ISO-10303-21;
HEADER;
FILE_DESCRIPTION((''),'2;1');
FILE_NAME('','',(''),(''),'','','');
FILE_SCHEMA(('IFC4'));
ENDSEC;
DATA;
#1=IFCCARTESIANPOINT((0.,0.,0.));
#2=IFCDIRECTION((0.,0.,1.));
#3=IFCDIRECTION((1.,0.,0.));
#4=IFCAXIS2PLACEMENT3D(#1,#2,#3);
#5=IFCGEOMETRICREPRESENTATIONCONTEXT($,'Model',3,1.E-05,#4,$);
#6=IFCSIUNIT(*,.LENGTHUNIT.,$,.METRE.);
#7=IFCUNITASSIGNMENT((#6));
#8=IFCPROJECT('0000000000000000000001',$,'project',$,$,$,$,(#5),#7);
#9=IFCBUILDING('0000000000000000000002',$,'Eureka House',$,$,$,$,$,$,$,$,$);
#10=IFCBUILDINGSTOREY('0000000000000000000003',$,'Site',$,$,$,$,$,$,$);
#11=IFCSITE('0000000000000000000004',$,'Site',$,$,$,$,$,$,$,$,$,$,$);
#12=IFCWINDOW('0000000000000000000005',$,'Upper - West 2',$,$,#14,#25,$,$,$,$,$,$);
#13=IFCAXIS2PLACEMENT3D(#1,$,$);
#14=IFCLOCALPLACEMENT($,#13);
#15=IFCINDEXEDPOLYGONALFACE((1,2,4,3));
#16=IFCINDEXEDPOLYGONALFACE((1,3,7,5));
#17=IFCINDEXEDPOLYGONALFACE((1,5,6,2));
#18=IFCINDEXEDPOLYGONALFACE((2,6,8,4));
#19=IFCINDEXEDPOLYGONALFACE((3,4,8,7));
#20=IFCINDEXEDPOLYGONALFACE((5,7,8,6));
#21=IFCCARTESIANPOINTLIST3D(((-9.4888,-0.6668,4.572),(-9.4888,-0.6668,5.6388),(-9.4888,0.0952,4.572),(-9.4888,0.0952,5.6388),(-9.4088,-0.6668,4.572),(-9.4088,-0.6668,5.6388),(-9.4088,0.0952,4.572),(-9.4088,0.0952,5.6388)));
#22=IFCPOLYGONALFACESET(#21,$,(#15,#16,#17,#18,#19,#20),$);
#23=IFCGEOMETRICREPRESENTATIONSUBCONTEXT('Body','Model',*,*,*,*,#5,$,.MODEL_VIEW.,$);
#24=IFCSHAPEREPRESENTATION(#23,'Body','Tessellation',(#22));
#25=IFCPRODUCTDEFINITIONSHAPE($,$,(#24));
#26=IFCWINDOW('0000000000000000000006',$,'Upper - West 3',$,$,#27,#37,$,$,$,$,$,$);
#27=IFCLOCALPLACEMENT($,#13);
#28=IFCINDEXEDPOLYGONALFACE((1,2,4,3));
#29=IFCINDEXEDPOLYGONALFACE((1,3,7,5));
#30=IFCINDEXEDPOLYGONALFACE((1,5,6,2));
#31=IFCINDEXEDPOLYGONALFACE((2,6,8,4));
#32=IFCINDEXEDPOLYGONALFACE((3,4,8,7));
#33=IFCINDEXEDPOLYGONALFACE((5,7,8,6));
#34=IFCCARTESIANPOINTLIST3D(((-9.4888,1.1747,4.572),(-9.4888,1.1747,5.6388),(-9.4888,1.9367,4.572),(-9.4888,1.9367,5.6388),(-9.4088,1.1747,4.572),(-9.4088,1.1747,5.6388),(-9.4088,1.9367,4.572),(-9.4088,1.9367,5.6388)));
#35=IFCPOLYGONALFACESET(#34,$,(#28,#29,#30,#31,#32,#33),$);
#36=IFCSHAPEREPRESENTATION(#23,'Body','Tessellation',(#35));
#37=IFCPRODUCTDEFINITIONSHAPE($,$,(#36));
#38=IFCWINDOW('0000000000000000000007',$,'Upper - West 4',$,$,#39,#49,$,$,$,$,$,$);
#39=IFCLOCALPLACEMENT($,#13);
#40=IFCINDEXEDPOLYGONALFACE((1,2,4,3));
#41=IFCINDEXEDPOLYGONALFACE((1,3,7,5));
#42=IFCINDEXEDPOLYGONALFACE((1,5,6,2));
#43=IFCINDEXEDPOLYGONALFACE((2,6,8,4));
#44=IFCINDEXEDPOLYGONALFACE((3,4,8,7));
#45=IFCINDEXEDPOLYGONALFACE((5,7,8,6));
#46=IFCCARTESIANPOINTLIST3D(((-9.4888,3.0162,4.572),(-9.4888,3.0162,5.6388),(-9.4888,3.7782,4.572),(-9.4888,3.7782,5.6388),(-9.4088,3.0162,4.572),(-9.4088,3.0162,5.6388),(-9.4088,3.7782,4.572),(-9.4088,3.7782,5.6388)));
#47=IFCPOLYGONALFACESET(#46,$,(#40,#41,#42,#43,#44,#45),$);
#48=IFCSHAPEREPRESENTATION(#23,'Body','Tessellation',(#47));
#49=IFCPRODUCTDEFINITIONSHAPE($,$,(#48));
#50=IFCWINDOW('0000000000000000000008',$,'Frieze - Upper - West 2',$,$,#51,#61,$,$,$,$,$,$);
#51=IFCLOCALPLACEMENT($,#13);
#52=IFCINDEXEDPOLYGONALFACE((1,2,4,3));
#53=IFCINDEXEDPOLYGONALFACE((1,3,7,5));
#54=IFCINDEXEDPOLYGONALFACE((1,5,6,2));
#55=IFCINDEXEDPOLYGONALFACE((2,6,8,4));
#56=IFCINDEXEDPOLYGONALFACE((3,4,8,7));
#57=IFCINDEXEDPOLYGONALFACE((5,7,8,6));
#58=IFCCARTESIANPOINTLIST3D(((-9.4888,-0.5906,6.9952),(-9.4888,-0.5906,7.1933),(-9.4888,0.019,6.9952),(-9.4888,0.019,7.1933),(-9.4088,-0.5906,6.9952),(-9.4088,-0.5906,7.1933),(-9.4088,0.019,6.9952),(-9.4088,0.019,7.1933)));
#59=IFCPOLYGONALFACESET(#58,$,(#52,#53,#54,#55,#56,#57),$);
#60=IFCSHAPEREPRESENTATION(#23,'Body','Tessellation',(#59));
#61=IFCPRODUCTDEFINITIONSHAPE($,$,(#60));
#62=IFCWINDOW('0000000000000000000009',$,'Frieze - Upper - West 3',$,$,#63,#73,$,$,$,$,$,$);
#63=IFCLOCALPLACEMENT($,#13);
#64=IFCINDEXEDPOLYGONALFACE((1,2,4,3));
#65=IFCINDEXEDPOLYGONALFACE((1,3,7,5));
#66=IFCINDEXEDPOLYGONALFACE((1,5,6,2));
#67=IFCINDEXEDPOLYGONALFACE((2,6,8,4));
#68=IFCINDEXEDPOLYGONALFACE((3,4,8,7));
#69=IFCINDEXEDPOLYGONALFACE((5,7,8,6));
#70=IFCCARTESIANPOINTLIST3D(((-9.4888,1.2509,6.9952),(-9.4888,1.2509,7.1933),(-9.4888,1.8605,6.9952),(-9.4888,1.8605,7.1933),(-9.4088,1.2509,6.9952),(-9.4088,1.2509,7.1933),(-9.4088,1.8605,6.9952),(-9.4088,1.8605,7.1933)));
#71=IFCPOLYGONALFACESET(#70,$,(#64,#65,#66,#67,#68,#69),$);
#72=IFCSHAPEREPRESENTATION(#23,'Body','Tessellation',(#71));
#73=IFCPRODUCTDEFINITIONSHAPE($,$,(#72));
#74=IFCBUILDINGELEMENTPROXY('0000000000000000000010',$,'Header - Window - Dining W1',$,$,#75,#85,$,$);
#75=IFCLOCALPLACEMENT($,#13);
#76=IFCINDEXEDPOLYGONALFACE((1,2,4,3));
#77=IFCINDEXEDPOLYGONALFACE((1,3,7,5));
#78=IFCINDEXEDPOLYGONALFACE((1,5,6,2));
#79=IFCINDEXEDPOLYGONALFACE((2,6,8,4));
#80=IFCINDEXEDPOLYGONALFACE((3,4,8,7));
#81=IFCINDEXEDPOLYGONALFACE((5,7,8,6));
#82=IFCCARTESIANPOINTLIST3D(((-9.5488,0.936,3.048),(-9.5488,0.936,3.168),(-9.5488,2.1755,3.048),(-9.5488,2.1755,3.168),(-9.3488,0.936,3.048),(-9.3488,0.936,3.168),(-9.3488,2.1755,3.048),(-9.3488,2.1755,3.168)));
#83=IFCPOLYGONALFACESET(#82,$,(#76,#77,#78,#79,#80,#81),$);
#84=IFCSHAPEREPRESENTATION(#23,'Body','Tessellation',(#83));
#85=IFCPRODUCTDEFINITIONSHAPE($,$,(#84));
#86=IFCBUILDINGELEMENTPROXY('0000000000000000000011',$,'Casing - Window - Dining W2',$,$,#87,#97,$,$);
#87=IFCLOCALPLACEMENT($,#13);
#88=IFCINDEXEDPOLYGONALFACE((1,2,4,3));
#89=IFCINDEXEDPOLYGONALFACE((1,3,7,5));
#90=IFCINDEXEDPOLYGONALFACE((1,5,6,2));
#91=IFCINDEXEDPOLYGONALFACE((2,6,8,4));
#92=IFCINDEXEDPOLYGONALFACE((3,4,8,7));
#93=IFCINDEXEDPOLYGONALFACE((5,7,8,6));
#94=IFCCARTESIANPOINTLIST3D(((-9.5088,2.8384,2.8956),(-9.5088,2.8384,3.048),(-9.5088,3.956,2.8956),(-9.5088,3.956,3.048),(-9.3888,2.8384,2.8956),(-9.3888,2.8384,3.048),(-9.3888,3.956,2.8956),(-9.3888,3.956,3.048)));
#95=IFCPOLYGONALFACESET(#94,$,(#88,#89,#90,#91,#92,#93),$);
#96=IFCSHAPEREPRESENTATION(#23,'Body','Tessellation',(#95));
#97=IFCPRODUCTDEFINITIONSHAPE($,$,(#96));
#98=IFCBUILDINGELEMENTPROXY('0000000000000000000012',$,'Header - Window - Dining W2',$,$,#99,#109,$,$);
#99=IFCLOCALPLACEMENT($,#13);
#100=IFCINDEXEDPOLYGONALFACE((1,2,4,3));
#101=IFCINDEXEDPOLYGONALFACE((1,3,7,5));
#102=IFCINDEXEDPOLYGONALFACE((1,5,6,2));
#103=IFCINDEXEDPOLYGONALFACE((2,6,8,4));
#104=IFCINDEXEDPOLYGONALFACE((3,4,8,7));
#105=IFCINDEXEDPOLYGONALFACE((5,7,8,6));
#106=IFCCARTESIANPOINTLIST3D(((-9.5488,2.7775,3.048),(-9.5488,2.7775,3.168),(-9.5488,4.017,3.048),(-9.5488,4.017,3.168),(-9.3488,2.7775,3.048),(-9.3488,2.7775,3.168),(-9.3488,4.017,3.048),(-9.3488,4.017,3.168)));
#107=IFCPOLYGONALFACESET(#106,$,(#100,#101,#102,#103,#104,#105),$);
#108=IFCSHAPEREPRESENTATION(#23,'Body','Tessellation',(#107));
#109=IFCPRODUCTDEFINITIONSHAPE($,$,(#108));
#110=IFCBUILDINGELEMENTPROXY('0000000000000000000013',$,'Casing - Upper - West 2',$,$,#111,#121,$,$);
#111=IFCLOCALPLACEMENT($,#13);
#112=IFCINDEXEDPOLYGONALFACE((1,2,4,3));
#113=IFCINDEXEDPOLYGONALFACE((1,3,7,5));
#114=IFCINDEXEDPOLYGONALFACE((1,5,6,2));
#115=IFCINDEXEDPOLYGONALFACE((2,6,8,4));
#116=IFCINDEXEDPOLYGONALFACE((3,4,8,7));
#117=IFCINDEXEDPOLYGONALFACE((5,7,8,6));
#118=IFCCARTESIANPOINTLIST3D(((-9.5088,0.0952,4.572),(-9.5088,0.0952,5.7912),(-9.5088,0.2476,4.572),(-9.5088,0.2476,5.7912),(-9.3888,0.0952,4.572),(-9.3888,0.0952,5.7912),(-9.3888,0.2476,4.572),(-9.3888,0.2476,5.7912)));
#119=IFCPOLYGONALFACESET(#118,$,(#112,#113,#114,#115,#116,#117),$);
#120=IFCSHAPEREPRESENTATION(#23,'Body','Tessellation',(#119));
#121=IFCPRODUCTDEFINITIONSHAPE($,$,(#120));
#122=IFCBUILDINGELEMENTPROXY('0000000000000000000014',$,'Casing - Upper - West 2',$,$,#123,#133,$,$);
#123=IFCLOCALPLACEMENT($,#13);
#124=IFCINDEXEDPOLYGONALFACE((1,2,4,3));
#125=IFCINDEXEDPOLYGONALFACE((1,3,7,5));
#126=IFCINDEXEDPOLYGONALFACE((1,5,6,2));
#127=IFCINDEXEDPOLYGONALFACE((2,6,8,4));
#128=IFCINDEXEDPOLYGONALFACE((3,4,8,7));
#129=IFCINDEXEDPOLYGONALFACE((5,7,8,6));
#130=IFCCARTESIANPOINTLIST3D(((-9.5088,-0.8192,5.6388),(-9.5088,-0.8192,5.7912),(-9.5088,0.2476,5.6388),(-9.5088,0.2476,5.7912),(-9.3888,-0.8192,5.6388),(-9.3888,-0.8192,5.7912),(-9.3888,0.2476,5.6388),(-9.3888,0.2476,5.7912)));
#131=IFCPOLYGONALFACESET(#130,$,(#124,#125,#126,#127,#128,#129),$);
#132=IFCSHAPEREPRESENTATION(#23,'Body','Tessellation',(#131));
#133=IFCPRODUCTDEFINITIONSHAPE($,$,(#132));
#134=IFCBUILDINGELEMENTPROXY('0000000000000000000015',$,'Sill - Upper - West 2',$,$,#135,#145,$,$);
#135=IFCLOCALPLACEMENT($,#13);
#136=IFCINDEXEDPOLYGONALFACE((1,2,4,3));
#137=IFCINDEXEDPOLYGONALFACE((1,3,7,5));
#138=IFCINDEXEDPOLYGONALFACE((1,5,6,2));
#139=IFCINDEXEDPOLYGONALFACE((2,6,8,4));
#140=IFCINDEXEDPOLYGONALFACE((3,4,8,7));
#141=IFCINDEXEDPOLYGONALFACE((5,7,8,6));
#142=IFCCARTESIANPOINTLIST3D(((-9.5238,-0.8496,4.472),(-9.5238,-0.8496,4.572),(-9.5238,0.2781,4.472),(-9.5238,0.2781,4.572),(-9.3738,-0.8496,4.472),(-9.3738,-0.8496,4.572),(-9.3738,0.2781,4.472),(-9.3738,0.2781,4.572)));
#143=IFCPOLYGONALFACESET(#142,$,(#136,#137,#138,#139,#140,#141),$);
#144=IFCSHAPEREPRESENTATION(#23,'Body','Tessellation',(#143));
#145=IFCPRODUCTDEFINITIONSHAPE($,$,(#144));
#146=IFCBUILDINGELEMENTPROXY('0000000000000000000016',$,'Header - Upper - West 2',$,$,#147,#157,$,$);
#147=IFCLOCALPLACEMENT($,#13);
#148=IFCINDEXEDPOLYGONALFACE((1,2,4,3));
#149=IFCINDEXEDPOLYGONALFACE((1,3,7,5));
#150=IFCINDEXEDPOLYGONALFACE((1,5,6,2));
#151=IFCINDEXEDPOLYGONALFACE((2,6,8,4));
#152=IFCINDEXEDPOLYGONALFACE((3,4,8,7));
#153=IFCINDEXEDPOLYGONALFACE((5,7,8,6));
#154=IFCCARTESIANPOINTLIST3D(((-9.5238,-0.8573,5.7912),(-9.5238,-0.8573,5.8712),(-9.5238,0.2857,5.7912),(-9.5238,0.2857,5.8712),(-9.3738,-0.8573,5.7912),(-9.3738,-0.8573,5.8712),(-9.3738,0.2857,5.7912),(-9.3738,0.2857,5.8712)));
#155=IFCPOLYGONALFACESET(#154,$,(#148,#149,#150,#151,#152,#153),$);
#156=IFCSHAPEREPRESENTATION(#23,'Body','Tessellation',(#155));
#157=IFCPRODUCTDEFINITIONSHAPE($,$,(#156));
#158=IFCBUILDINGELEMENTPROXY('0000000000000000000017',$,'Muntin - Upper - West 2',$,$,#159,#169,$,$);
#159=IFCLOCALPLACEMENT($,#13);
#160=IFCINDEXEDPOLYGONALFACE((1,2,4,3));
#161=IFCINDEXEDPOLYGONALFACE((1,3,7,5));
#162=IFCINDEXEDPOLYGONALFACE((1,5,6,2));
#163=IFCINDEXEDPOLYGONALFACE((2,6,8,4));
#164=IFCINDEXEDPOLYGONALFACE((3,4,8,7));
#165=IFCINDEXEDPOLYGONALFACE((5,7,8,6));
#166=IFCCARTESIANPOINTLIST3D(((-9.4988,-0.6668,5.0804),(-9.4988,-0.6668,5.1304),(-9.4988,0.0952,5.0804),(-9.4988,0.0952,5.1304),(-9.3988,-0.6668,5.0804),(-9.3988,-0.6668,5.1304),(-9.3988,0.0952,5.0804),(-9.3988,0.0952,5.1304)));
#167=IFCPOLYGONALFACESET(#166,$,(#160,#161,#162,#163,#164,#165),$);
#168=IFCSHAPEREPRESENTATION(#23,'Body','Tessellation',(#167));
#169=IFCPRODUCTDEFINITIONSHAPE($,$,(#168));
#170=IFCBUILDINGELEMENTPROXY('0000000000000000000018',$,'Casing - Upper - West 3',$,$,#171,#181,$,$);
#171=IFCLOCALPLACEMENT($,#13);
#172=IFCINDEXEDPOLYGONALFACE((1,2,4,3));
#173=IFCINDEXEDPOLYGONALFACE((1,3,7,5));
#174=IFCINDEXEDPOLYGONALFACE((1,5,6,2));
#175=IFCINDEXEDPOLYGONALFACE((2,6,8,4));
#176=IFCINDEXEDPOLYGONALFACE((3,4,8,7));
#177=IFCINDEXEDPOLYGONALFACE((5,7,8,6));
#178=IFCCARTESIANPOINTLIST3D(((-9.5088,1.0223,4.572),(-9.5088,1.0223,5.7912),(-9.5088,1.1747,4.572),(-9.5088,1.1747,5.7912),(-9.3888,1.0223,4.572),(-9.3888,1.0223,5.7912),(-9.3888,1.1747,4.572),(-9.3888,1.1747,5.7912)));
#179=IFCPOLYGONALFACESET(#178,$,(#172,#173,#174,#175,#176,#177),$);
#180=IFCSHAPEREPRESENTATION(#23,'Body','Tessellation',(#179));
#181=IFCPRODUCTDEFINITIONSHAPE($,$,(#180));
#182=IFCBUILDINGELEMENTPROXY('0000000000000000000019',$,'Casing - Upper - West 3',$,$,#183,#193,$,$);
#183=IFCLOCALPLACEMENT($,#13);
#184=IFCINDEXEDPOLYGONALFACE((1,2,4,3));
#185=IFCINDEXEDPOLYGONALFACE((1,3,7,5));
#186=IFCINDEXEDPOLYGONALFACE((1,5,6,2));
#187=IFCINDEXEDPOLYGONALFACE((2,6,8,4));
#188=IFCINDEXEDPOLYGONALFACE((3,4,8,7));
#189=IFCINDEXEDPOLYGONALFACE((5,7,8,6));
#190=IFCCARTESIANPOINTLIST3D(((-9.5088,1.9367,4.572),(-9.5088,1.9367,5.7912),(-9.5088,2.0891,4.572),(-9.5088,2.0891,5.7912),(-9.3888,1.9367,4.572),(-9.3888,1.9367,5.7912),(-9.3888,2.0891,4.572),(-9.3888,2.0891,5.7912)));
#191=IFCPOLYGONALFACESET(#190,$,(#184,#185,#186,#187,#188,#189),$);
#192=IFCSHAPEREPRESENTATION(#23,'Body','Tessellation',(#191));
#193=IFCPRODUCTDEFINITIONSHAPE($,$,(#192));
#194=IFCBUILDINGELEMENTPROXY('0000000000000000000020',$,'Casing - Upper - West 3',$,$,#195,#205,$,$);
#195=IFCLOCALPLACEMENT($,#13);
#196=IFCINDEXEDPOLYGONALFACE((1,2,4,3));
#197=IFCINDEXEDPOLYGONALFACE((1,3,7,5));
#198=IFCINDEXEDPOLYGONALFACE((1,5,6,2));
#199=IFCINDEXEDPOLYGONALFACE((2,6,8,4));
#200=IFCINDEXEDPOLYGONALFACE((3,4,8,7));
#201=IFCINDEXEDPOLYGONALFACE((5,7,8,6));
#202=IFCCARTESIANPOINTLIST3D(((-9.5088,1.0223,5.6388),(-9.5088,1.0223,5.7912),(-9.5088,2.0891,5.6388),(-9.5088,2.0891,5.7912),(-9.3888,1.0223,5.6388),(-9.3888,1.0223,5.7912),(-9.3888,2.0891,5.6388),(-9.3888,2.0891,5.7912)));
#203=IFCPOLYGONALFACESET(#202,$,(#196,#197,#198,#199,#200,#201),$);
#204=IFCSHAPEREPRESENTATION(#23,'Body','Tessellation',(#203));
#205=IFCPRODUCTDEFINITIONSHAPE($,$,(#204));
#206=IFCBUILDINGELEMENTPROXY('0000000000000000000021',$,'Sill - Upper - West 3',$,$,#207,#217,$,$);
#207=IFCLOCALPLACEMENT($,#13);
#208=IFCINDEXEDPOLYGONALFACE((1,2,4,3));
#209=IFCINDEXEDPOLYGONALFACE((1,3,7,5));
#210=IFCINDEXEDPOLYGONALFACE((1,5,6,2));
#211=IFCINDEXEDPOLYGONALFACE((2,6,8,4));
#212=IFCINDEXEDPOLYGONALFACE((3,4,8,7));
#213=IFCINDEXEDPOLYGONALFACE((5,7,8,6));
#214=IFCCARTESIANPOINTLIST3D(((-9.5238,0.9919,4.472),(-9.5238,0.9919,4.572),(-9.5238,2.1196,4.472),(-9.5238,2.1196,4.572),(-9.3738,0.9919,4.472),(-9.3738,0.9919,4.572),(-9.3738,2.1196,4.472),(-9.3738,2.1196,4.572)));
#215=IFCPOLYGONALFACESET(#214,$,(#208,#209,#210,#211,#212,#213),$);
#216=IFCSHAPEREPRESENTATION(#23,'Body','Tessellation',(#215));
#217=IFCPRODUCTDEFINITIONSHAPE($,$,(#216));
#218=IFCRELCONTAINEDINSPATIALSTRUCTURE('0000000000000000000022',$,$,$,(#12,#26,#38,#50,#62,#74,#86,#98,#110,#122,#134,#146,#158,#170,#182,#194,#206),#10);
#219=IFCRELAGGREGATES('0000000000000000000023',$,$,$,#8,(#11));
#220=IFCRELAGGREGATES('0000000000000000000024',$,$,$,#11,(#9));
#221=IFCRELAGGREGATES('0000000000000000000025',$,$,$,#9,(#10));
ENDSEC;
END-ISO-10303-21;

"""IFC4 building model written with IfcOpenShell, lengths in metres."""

from ifc_helpers import new_model, si_unit, frame, origin, origin_with_axes, origin_2d, place, context, subcontext, project, spatial, rectangle, extrude, element, save


model = new_model("IFC4")

# Units and contexts
model_context = context("Model", 3, precision=1e-05, world=origin_with_axes())
body_context = subcontext(model_context, "Body", "Model", "MODEL_VIEW")
ifc_project = project(units=[si_unit("LENGTHUNIT", "METRE")], contexts=[model_context])

# Site, building, storey
site = spatial("IfcSite", under=ifc_project, Name="Site")
building = spatial("IfcBuilding", under=site, Name="Eureka House")
storey = spatial("IfcBuildingStorey", under=building, Name="Site")

# Windows
for number, where, z_axis, x_axis, name in (
    (1, (-9.4488, -0.2858, 4.572), (0.0, 0.0, 1.0), (1.0, 0.0, 0.0), "Upper - West 2"),
    (2, (-9.4488, 1.5557, 4.572), (0.0, 0.0, 1.0), (1.0, 0.0, 0.0), "Upper - West 3"),
    (3, (-9.4488, 3.3972, 4.572), (0.0, 0.0, 1.0), (1.0, 0.0, 0.0), "Upper - West 4"),
):
    element("IfcWindow", number, at=place(None, frame(where, z_axis=z_axis, x_axis=x_axis)), inside=storey, Name=name, context=body_context, shape_type="SweptSolid", body=[
        extrude(rectangle(XDim=0.08, YDim=0.762, at=origin_2d()), origin(), (0.0, 0.0, 1.0), 1.0668),
    ])
for number, where, z_axis, x_axis, name in (
    (4, (-9.4488, -0.2858, 6.9952), (0.0, 0.0, 1.0), (1.0, 0.0, 0.0), "Frieze - Upper - West 2"),
    (5, (-9.4488, 1.5557, 6.9952), (0.0, 0.0, 1.0), (1.0, 0.0, 0.0), "Frieze - Upper - West 3"),
):
    element("IfcWindow", number, at=place(None, frame(where, z_axis=z_axis, x_axis=x_axis)), inside=storey, Name=name, context=body_context, shape_type="SweptSolid", body=[
        extrude(rectangle(XDim=0.08, YDim=0.6096, at=origin_2d()), origin(), (0.0, 0.0, 1.0), 0.1981),
    ])

# Building element proxies
proxy_1_placement = place(None, frame((-9.4488, 1.5557, 3.048), z_axis=(0.0, 0.0, 1.0), x_axis=(1.0, 0.0, 0.0)))
element("IfcBuildingElementProxy", 6, at=proxy_1_placement, inside=storey, Name="Header - Window - Dining W1", context=body_context, shape_type="SweptSolid", body=[
    extrude(rectangle(XDim=0.2, YDim=1.2395, at=origin_2d()), origin(), (0.0, 0.0, 1.0), 0.12),
])
proxy_2_placement = place(None, frame((-9.4488, 3.3972, 2.8956), z_axis=(0.0, 0.0, 1.0), x_axis=(1.0, 0.0, 0.0)))
element("IfcBuildingElementProxy", 7, at=proxy_2_placement, inside=storey, Name="Casing - Window - Dining W2", context=body_context, shape_type="SweptSolid", body=[
    extrude(rectangle(XDim=0.12, YDim=1.1176, at=origin_2d()), origin(), (0.0, 0.0, 1.0), 0.1524),
])
proxy_3_placement = place(None, frame((-9.4488, 3.3972, 3.048), z_axis=(0.0, 0.0, 1.0), x_axis=(1.0, 0.0, 0.0)))
element("IfcBuildingElementProxy", 8, at=proxy_3_placement, inside=storey, Name="Header - Window - Dining W2", context=body_context, shape_type="SweptSolid", body=[
    extrude(rectangle(XDim=0.2, YDim=1.2395, at=origin_2d()), origin(), (0.0, 0.0, 1.0), 0.12),
])
proxy_4_placement = place(None, frame((-9.4488, 0.1714, 4.572), z_axis=(0.0, 0.0, 1.0), x_axis=(1.0, 0.0, 0.0)))
element("IfcBuildingElementProxy", 9, at=proxy_4_placement, inside=storey, Name="Casing - Upper - West 2", context=body_context, shape_type="SweptSolid", body=[
    extrude(rectangle(XDim=0.12, YDim=0.1524, at=origin_2d()), origin(), (0.0, 0.0, 1.0), 1.2192),
])
proxy_5_placement = place(None, frame((-9.4488, -0.2858, 5.6388), z_axis=(0.0, 0.0, 1.0), x_axis=(1.0, 0.0, 0.0)))
element("IfcBuildingElementProxy", 10, at=proxy_5_placement, inside=storey, Name="Casing - Upper - West 2", context=body_context, shape_type="SweptSolid", body=[
    extrude(rectangle(XDim=0.12, YDim=1.0668, at=origin_2d()), origin(), (0.0, 0.0, 1.0), 0.1524),
])
proxy_6_placement = place(None, frame((-9.4488, -0.2858, 4.472), z_axis=(0.0, 0.0, 1.0), x_axis=(1.0, 0.0, 0.0)))
element("IfcBuildingElementProxy", 11, at=proxy_6_placement, inside=storey, Name="Sill - Upper - West 2", context=body_context, shape_type="SweptSolid", body=[
    extrude(rectangle(XDim=0.15, YDim=1.1278, at=origin_2d()), origin(), (0.0, 0.0, 1.0), 0.1),
])
proxy_7_placement = place(None, frame((-9.4488, -0.2858, 5.7912), z_axis=(0.0, 0.0, 1.0), x_axis=(1.0, 0.0, 0.0)))
element("IfcBuildingElementProxy", 12, at=proxy_7_placement, inside=storey, Name="Header - Upper - West 2", context=body_context, shape_type="SweptSolid", body=[
    extrude(rectangle(XDim=0.15, YDim=1.143, at=origin_2d()), origin(), (0.0, 0.0, 1.0), 0.08),
])
proxy_8_placement = place(None, frame((-9.4488, -0.2858, 5.0804), z_axis=(0.0, 0.0, 1.0), x_axis=(1.0, 0.0, 0.0)))
element("IfcBuildingElementProxy", 13, at=proxy_8_placement, inside=storey, Name="Muntin - Upper - West 2", context=body_context, shape_type="SweptSolid", body=[
    extrude(rectangle(XDim=0.1, YDim=0.762, at=origin_2d()), origin(), (0.0, 0.0, 1.0), 0.05),
])
for number, where, z_axis, x_axis, name in (
    (14, (-9.4488, 1.0985, 4.572), (0.0, 0.0, 1.0), (1.0, 0.0, 0.0), "Casing - Upper - West 3"),
    (15, (-9.4488, 2.0129, 4.572), (0.0, 0.0, 1.0), (1.0, 0.0, 0.0), "Casing - Upper - West 3"),
):
    element("IfcBuildingElementProxy", number, at=place(None, frame(where, z_axis=z_axis, x_axis=x_axis)), inside=storey, Name=name, context=body_context, shape_type="SweptSolid", body=[
        extrude(rectangle(XDim=0.12, YDim=0.1524, at=origin_2d()), origin(), (0.0, 0.0, 1.0), 1.2192),
    ])
proxy_9_placement = place(None, frame((-9.4488, 1.5557, 5.6388), z_axis=(0.0, 0.0, 1.0), x_axis=(1.0, 0.0, 0.0)))
element("IfcBuildingElementProxy", 16, at=proxy_9_placement, inside=storey, Name="Casing - Upper - West 3", context=body_context, shape_type="SweptSolid", body=[
    extrude(rectangle(XDim=0.12, YDim=1.0668, at=origin_2d()), origin(), (0.0, 0.0, 1.0), 0.1524),
])
proxy_10_placement = place(None, frame((-9.4488, 1.5557, 4.472), z_axis=(0.0, 0.0, 1.0), x_axis=(1.0, 0.0, 0.0)))
element("IfcBuildingElementProxy", 17, at=proxy_10_placement, inside=storey, Name="Sill - Upper - West 3", context=body_context, shape_type="SweptSolid", body=[
    extrude(rectangle(XDim=0.15, YDim=1.1278, at=origin_2d()), origin(), (0.0, 0.0, 1.0), 0.1),
])

save(model, "model.ifc")
